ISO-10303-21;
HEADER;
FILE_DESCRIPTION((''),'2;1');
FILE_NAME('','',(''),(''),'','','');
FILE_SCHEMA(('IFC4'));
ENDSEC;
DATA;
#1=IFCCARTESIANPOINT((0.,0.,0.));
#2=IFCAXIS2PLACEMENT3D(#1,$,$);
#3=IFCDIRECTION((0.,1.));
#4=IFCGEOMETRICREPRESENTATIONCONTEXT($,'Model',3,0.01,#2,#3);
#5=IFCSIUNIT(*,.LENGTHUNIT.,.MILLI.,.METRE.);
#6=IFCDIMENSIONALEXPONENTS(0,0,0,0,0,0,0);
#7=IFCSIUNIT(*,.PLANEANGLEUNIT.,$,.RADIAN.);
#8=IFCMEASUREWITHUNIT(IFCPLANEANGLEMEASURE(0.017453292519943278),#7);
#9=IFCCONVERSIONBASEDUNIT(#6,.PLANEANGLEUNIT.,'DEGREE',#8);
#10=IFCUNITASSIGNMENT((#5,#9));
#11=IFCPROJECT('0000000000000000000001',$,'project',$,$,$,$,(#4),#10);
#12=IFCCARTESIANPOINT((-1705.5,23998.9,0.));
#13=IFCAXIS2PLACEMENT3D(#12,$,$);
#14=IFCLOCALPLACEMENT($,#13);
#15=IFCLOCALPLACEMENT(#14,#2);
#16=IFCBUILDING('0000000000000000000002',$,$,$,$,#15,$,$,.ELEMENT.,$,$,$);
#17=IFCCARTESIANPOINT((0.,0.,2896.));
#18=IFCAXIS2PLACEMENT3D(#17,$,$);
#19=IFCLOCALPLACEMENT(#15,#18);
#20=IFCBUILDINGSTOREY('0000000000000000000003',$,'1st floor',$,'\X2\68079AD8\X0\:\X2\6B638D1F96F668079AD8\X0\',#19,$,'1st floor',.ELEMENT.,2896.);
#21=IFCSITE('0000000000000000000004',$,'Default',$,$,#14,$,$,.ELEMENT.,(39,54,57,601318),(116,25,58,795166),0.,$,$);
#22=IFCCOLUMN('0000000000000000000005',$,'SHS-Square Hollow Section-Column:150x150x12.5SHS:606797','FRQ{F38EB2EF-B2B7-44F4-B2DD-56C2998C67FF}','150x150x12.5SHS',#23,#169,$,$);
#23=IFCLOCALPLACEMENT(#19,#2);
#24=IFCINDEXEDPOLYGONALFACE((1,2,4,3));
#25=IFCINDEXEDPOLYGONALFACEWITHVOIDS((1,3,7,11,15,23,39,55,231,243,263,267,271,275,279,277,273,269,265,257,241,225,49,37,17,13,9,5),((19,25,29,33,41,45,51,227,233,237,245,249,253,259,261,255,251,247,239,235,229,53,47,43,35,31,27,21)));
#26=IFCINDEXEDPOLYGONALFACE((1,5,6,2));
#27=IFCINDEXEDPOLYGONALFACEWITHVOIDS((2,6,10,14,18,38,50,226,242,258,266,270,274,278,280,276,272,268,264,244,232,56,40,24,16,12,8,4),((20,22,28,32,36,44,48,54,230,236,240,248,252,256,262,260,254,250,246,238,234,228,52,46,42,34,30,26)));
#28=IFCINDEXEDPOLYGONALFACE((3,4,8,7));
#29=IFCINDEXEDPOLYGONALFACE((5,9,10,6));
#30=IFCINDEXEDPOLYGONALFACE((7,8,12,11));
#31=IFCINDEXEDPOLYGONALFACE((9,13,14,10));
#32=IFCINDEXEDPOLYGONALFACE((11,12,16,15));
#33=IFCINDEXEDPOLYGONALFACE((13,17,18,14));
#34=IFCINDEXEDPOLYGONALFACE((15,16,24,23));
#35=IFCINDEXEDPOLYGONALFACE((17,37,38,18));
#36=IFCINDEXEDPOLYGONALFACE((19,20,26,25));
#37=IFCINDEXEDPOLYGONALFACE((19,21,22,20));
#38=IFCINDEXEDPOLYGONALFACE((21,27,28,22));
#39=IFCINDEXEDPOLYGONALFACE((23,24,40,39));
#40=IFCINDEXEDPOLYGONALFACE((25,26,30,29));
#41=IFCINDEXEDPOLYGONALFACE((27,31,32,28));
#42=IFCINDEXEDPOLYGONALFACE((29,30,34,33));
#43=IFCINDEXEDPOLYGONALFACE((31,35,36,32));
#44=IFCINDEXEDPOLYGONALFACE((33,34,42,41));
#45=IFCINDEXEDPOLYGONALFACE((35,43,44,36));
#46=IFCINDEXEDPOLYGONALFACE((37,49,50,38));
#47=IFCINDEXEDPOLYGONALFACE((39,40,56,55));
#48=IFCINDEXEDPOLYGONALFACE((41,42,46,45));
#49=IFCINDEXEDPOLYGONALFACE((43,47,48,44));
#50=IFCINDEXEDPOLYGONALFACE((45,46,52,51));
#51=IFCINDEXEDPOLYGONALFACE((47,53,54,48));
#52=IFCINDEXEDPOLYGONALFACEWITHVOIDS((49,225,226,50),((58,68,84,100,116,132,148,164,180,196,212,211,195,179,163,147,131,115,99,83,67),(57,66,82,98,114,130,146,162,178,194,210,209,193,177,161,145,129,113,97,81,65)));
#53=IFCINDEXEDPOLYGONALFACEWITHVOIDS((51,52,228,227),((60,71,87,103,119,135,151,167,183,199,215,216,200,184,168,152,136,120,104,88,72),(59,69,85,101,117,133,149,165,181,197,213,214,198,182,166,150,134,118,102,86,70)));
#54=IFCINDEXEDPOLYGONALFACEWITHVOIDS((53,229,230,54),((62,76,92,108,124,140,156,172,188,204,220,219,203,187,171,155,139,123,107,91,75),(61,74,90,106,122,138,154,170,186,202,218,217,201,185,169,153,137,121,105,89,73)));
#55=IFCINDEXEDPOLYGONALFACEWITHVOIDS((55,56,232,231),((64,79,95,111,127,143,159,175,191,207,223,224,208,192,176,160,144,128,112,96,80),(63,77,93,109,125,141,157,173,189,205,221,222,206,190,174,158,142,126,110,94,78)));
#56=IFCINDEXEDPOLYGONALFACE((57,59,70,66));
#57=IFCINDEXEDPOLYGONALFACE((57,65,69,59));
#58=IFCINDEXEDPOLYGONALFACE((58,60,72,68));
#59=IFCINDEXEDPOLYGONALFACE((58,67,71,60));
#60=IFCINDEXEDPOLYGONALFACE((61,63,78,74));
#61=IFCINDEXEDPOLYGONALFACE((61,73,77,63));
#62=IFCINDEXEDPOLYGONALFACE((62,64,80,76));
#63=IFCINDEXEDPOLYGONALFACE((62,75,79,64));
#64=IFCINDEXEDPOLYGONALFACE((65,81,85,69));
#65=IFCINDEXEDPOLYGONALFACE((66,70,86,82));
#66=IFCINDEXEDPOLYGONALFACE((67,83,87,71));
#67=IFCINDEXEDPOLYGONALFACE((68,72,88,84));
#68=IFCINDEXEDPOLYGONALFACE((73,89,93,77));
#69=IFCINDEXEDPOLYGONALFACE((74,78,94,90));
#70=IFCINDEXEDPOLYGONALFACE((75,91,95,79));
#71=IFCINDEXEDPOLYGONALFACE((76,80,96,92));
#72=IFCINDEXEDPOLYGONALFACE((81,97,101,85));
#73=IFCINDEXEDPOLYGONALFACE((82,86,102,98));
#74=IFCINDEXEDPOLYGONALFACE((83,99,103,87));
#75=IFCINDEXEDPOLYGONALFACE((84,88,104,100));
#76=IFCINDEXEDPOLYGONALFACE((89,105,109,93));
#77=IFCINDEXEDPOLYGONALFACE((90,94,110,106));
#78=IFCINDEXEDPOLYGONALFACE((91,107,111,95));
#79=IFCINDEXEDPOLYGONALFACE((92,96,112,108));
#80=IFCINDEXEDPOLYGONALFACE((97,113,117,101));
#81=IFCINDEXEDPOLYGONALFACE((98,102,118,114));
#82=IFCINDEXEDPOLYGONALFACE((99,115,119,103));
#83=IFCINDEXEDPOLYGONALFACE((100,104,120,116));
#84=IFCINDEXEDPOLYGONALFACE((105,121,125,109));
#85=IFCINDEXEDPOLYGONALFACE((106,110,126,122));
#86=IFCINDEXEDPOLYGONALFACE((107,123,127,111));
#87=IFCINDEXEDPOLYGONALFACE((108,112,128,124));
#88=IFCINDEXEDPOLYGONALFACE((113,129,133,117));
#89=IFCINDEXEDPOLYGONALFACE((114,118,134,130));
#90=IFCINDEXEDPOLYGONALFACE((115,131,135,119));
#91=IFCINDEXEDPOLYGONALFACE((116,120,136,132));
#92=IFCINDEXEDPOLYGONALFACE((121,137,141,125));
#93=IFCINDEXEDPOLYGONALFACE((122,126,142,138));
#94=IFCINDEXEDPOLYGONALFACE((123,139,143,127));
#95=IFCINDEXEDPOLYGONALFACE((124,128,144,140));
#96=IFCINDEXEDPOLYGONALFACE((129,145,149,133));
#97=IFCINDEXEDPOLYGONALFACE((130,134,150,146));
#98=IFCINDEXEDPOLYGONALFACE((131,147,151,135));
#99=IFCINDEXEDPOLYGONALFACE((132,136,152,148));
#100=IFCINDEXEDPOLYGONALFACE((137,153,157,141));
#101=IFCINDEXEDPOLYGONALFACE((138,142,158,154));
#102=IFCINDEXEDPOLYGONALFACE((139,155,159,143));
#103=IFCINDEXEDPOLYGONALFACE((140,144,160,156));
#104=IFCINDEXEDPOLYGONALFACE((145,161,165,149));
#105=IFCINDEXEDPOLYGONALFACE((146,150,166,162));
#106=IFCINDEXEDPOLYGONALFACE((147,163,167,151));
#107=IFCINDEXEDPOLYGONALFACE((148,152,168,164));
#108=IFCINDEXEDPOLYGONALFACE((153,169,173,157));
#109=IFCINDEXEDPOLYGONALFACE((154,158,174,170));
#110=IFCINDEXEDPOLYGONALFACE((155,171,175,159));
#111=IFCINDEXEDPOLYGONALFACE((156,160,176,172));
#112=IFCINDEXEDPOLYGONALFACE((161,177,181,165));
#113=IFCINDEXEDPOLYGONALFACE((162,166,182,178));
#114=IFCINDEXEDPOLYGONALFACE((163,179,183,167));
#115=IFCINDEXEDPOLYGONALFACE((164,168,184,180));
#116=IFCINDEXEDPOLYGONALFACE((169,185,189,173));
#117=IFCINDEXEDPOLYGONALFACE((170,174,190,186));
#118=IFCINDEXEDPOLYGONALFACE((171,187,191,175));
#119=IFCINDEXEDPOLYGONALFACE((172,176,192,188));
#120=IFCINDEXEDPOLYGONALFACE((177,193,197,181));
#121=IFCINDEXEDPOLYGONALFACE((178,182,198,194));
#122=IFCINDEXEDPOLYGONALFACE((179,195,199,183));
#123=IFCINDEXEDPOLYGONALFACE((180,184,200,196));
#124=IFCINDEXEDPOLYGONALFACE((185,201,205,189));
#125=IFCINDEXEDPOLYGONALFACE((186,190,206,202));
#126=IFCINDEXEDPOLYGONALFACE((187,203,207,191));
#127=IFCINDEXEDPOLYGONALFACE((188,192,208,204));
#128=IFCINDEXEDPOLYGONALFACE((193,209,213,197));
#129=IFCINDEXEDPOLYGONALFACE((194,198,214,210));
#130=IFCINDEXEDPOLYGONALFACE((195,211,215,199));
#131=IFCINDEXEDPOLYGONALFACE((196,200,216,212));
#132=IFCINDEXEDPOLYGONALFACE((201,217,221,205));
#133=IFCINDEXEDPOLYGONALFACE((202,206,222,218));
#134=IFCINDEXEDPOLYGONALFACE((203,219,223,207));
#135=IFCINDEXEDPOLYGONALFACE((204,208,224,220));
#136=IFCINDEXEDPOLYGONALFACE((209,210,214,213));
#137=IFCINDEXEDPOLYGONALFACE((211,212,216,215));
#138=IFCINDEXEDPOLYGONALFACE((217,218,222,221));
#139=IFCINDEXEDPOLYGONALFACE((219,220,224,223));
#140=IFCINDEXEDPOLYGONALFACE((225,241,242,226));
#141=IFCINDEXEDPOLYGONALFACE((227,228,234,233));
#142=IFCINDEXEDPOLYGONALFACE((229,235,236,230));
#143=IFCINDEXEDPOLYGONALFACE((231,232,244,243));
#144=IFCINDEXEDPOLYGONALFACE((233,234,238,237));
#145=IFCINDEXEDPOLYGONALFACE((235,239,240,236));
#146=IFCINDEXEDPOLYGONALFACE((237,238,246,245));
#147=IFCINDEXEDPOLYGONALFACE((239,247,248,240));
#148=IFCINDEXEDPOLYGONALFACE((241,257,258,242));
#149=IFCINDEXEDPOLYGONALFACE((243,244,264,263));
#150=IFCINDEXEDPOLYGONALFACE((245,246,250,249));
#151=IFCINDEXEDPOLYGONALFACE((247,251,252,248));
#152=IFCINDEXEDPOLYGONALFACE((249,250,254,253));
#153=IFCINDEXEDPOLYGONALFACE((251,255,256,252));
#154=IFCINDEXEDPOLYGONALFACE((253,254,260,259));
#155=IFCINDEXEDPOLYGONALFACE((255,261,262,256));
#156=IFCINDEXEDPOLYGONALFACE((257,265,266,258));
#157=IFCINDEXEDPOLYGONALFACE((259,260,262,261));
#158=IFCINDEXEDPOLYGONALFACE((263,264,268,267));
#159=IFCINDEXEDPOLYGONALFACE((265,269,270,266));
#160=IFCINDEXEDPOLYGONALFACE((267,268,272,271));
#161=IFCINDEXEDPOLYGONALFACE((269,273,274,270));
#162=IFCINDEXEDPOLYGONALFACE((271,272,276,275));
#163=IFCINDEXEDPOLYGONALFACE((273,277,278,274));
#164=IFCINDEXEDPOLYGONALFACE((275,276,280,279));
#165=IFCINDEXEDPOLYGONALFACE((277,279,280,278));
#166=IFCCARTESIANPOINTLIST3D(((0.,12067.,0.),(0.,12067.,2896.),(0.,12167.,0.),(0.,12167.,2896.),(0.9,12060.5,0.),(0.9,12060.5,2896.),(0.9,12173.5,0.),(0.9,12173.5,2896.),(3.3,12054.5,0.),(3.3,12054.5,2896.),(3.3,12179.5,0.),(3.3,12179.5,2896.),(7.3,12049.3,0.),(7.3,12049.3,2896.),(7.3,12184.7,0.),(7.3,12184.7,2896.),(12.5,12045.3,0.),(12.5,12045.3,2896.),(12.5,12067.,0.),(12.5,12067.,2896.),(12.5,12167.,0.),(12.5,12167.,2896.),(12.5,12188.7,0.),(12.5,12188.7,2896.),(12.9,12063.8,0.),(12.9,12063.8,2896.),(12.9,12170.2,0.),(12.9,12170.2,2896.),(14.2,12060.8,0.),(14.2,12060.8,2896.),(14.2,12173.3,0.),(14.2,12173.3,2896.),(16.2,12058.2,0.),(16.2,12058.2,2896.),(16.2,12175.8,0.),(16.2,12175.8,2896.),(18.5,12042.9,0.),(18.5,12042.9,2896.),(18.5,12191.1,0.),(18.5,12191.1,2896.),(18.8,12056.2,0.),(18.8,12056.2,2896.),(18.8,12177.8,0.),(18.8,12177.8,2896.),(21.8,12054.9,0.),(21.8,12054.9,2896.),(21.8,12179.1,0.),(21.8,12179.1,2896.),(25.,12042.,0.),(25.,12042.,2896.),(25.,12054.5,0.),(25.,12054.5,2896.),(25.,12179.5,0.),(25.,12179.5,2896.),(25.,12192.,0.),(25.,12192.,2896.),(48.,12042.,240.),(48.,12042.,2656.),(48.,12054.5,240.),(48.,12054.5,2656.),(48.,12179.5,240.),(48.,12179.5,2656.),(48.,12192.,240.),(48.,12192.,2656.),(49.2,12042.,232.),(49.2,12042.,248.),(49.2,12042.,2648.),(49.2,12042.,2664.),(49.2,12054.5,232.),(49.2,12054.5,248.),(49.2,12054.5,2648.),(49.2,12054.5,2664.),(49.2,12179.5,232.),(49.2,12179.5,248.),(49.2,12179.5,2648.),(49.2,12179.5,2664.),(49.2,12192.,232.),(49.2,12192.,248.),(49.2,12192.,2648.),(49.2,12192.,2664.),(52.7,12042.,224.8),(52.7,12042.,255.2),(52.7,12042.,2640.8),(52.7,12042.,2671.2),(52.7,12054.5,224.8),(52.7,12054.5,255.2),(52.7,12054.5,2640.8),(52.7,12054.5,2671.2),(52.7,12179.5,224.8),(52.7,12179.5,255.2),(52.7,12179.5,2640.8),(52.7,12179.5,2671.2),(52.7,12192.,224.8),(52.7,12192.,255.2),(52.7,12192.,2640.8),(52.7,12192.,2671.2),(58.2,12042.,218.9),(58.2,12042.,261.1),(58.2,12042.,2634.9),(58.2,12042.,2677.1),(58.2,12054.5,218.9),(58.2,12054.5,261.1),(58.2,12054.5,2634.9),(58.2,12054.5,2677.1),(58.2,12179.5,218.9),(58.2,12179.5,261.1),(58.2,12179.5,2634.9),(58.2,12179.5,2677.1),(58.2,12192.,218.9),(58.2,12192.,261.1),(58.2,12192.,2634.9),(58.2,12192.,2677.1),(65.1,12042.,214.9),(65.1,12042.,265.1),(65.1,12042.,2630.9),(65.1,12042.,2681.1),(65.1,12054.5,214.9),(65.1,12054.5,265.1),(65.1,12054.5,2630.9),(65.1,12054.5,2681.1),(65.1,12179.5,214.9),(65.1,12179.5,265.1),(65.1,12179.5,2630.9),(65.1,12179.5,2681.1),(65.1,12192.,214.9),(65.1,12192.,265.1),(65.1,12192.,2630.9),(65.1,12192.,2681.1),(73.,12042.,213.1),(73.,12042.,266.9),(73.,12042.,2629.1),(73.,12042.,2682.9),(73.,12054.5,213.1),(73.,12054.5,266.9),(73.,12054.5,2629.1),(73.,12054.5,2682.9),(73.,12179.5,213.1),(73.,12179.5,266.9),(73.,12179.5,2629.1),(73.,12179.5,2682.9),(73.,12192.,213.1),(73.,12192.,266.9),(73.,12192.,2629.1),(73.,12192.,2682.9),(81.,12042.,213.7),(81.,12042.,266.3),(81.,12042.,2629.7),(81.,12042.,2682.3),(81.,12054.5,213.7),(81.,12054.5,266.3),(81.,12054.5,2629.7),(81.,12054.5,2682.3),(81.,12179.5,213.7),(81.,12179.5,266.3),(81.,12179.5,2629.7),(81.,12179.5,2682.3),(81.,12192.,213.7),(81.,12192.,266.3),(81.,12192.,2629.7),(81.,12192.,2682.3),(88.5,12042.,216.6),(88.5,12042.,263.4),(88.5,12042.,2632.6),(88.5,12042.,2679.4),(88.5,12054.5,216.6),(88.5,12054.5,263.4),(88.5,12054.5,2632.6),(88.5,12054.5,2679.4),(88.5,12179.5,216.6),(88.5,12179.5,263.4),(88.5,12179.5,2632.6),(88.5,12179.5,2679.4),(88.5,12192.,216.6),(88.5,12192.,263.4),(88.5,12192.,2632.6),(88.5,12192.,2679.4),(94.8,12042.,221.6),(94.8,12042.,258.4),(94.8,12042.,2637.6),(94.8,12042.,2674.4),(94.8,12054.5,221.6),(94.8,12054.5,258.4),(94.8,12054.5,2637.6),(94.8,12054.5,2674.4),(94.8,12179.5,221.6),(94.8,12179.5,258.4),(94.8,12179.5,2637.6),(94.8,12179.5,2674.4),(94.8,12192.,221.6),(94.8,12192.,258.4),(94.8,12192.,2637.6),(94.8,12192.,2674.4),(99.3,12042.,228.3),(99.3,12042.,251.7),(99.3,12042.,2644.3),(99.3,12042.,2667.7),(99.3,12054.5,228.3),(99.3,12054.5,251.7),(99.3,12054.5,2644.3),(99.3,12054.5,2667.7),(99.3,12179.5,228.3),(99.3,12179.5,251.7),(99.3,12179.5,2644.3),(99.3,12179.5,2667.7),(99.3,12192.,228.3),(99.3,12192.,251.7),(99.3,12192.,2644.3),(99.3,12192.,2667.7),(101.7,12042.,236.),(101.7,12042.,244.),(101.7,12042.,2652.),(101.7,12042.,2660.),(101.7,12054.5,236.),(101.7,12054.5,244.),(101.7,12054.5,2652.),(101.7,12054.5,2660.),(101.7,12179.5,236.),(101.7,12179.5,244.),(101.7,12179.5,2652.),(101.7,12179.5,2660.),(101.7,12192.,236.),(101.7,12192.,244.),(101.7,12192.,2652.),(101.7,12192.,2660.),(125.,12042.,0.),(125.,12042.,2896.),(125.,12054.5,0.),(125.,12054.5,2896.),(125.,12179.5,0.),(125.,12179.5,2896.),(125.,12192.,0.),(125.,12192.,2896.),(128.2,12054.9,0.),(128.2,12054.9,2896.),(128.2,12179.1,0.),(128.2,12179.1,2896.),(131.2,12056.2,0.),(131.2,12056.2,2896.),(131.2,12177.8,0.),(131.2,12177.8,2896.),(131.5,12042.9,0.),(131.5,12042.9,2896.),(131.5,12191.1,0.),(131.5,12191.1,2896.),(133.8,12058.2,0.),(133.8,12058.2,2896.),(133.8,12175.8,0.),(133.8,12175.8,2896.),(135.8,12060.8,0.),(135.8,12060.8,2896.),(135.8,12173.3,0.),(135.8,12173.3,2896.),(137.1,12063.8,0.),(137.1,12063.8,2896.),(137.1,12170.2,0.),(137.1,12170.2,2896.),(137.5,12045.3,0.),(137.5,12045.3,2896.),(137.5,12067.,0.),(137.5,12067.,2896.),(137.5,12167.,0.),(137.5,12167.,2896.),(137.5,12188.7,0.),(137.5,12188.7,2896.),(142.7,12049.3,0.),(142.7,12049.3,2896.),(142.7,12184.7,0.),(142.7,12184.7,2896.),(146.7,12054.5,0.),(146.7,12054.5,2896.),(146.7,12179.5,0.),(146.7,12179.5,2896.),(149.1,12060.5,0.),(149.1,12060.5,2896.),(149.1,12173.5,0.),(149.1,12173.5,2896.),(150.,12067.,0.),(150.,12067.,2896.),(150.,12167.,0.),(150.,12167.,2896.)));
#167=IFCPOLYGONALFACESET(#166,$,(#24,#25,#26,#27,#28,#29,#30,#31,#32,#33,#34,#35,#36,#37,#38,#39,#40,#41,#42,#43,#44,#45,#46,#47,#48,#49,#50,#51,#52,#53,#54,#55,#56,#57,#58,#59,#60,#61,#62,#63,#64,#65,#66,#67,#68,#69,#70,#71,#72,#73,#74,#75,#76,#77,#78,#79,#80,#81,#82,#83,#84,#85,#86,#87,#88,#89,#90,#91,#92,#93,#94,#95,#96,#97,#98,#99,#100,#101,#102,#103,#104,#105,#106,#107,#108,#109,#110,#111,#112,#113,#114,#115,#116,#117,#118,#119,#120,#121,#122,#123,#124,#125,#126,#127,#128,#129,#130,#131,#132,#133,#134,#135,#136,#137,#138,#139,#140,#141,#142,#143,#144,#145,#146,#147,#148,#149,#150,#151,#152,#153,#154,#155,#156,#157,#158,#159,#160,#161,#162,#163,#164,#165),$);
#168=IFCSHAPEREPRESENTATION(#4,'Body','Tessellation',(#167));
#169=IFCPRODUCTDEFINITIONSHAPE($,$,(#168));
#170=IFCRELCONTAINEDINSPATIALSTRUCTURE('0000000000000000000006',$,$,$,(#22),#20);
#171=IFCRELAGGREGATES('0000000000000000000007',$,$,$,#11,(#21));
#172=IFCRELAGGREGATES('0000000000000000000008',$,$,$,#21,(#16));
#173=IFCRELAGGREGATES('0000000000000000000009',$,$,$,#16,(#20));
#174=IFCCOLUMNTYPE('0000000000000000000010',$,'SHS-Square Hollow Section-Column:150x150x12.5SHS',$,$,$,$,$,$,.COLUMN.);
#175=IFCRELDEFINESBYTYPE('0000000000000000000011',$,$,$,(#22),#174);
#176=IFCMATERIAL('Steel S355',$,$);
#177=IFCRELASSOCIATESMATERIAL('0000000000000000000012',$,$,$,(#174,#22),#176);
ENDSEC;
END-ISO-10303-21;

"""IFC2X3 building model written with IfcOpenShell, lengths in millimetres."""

from ifc_helpers import new_model, entity, si_unit, converted_unit, direction, frame, frame_2d, origin, origin_2d, place, context, project, spatial, circle_curve, hollow_rectangle, outline, extrude, material, type_object, element, save


model = new_model("IFC2X3")

# Units and contexts
model_context = context("Model", 3, precision=0.01, world=origin(), true_north=direction((0.0, 1.0)))
ifc_project = project(units=[si_unit("LENGTHUNIT", "METRE", prefix="MILLI"), converted_unit("PLANEANGLEUNIT", "DEGREE", entity("IfcPlaneAngleMeasure", 0.017453292519943278), si_unit("PLANEANGLEUNIT", "RADIAN"), dimensions=[0, 0, 0, 0, 0, 0, 0])], contexts=[model_context])

# Site, building, storey
site_placement = place(None, frame((-1705.5, 23998.9, 0.0)))
site = spatial("IfcSite", under=ifc_project, at=site_placement, Name="Default", CompositionType="ELEMENT", RefLatitude=(39, 54, 57, 601318), RefLongitude=(116, 25, 58, 795166), RefElevation=0.0)
building_placement = place(site_placement, origin())
building = spatial("IfcBuilding", under=site, at=building_placement, CompositionType="ELEMENT")
storey_placement = place(building_placement, frame((0.0, 0.0, 2896.0)))
storey = spatial("IfcBuildingStorey", under=building, at=storey_placement, Name="1st floor", ObjectType="标高:正负零标高", LongName="1st floor", CompositionType="ELEMENT", Elevation=2896.0)

# Shared definitions
ifc_material_1 = material(Name="Steel S355")

# Column, openings
column_type_1 = type_object("IfcColumnType", Name="SHS-Square Hollow Section-Column:150x150x12.5SHS", PredefinedType="COLUMN", material=ifc_material_1)
column_1_placement = place(storey_placement, frame((75.0, 12117.0, 2896.0), z_axis=(0.0, 0.0, 1.0), x_axis=(0.0, -1.0, 0.0)))
column_1 = element("IfcColumn", 1, at=column_1_placement, inside=storey, type_object=column_type_1, material=ifc_material_1, Name="SHS-Square Hollow Section-Column:150x150x12.5SHS:606797", Description="FRQ{F38EB2EF-B2B7-44F4-B2DD-56C2998C67FF}", ObjectType="150x150x12.5SHS", context=model_context, shape_type="SweptSolid", body=[
    extrude(hollow_rectangle(XDim=150.0, YDim=150.0, WallThickness=12.5, InnerFilletRadius=12.5, OuterFilletRadius=25.0, at=origin_2d()), origin(), (0.0, 0.0, -1.0), 2896.0),
])
opening_1_placement = place(column_1_placement, frame((175.1, 0.0, -2896.0), z_axis=(-1.0, 0.0, 0.0), x_axis=(0.0, -1.0, 0.0)))
element("IfcOpeningElement", 2, at=opening_1_placement, cuts=column_1, ObjectType="Opening", context=model_context, shape_type="SweptSolid", body=[
    extrude(outline(circle_curve(frame_2d((0.0, 240.0), x_axis=(1.0, 0.0)), 27.0)), origin(), (0.0, 0.0, 1.0), 350.2),
])
opening_2_placement = place(column_1_placement, frame((175.1, 0.0, 0.0), z_axis=(-1.0, 0.0, 0.0), x_axis=(0.0, -1.0, 0.0)))
element("IfcOpeningElement", 3, at=opening_2_placement, cuts=column_1, ObjectType="Opening", context=model_context, shape_type="SweptSolid", body=[
    extrude(outline(circle_curve(frame_2d((0.0, -240.0), x_axis=(1.0, 0.0)), 27.0)), origin(), (0.0, 0.0, 1.0), 350.2),
])

save(model, "model.ifc")
